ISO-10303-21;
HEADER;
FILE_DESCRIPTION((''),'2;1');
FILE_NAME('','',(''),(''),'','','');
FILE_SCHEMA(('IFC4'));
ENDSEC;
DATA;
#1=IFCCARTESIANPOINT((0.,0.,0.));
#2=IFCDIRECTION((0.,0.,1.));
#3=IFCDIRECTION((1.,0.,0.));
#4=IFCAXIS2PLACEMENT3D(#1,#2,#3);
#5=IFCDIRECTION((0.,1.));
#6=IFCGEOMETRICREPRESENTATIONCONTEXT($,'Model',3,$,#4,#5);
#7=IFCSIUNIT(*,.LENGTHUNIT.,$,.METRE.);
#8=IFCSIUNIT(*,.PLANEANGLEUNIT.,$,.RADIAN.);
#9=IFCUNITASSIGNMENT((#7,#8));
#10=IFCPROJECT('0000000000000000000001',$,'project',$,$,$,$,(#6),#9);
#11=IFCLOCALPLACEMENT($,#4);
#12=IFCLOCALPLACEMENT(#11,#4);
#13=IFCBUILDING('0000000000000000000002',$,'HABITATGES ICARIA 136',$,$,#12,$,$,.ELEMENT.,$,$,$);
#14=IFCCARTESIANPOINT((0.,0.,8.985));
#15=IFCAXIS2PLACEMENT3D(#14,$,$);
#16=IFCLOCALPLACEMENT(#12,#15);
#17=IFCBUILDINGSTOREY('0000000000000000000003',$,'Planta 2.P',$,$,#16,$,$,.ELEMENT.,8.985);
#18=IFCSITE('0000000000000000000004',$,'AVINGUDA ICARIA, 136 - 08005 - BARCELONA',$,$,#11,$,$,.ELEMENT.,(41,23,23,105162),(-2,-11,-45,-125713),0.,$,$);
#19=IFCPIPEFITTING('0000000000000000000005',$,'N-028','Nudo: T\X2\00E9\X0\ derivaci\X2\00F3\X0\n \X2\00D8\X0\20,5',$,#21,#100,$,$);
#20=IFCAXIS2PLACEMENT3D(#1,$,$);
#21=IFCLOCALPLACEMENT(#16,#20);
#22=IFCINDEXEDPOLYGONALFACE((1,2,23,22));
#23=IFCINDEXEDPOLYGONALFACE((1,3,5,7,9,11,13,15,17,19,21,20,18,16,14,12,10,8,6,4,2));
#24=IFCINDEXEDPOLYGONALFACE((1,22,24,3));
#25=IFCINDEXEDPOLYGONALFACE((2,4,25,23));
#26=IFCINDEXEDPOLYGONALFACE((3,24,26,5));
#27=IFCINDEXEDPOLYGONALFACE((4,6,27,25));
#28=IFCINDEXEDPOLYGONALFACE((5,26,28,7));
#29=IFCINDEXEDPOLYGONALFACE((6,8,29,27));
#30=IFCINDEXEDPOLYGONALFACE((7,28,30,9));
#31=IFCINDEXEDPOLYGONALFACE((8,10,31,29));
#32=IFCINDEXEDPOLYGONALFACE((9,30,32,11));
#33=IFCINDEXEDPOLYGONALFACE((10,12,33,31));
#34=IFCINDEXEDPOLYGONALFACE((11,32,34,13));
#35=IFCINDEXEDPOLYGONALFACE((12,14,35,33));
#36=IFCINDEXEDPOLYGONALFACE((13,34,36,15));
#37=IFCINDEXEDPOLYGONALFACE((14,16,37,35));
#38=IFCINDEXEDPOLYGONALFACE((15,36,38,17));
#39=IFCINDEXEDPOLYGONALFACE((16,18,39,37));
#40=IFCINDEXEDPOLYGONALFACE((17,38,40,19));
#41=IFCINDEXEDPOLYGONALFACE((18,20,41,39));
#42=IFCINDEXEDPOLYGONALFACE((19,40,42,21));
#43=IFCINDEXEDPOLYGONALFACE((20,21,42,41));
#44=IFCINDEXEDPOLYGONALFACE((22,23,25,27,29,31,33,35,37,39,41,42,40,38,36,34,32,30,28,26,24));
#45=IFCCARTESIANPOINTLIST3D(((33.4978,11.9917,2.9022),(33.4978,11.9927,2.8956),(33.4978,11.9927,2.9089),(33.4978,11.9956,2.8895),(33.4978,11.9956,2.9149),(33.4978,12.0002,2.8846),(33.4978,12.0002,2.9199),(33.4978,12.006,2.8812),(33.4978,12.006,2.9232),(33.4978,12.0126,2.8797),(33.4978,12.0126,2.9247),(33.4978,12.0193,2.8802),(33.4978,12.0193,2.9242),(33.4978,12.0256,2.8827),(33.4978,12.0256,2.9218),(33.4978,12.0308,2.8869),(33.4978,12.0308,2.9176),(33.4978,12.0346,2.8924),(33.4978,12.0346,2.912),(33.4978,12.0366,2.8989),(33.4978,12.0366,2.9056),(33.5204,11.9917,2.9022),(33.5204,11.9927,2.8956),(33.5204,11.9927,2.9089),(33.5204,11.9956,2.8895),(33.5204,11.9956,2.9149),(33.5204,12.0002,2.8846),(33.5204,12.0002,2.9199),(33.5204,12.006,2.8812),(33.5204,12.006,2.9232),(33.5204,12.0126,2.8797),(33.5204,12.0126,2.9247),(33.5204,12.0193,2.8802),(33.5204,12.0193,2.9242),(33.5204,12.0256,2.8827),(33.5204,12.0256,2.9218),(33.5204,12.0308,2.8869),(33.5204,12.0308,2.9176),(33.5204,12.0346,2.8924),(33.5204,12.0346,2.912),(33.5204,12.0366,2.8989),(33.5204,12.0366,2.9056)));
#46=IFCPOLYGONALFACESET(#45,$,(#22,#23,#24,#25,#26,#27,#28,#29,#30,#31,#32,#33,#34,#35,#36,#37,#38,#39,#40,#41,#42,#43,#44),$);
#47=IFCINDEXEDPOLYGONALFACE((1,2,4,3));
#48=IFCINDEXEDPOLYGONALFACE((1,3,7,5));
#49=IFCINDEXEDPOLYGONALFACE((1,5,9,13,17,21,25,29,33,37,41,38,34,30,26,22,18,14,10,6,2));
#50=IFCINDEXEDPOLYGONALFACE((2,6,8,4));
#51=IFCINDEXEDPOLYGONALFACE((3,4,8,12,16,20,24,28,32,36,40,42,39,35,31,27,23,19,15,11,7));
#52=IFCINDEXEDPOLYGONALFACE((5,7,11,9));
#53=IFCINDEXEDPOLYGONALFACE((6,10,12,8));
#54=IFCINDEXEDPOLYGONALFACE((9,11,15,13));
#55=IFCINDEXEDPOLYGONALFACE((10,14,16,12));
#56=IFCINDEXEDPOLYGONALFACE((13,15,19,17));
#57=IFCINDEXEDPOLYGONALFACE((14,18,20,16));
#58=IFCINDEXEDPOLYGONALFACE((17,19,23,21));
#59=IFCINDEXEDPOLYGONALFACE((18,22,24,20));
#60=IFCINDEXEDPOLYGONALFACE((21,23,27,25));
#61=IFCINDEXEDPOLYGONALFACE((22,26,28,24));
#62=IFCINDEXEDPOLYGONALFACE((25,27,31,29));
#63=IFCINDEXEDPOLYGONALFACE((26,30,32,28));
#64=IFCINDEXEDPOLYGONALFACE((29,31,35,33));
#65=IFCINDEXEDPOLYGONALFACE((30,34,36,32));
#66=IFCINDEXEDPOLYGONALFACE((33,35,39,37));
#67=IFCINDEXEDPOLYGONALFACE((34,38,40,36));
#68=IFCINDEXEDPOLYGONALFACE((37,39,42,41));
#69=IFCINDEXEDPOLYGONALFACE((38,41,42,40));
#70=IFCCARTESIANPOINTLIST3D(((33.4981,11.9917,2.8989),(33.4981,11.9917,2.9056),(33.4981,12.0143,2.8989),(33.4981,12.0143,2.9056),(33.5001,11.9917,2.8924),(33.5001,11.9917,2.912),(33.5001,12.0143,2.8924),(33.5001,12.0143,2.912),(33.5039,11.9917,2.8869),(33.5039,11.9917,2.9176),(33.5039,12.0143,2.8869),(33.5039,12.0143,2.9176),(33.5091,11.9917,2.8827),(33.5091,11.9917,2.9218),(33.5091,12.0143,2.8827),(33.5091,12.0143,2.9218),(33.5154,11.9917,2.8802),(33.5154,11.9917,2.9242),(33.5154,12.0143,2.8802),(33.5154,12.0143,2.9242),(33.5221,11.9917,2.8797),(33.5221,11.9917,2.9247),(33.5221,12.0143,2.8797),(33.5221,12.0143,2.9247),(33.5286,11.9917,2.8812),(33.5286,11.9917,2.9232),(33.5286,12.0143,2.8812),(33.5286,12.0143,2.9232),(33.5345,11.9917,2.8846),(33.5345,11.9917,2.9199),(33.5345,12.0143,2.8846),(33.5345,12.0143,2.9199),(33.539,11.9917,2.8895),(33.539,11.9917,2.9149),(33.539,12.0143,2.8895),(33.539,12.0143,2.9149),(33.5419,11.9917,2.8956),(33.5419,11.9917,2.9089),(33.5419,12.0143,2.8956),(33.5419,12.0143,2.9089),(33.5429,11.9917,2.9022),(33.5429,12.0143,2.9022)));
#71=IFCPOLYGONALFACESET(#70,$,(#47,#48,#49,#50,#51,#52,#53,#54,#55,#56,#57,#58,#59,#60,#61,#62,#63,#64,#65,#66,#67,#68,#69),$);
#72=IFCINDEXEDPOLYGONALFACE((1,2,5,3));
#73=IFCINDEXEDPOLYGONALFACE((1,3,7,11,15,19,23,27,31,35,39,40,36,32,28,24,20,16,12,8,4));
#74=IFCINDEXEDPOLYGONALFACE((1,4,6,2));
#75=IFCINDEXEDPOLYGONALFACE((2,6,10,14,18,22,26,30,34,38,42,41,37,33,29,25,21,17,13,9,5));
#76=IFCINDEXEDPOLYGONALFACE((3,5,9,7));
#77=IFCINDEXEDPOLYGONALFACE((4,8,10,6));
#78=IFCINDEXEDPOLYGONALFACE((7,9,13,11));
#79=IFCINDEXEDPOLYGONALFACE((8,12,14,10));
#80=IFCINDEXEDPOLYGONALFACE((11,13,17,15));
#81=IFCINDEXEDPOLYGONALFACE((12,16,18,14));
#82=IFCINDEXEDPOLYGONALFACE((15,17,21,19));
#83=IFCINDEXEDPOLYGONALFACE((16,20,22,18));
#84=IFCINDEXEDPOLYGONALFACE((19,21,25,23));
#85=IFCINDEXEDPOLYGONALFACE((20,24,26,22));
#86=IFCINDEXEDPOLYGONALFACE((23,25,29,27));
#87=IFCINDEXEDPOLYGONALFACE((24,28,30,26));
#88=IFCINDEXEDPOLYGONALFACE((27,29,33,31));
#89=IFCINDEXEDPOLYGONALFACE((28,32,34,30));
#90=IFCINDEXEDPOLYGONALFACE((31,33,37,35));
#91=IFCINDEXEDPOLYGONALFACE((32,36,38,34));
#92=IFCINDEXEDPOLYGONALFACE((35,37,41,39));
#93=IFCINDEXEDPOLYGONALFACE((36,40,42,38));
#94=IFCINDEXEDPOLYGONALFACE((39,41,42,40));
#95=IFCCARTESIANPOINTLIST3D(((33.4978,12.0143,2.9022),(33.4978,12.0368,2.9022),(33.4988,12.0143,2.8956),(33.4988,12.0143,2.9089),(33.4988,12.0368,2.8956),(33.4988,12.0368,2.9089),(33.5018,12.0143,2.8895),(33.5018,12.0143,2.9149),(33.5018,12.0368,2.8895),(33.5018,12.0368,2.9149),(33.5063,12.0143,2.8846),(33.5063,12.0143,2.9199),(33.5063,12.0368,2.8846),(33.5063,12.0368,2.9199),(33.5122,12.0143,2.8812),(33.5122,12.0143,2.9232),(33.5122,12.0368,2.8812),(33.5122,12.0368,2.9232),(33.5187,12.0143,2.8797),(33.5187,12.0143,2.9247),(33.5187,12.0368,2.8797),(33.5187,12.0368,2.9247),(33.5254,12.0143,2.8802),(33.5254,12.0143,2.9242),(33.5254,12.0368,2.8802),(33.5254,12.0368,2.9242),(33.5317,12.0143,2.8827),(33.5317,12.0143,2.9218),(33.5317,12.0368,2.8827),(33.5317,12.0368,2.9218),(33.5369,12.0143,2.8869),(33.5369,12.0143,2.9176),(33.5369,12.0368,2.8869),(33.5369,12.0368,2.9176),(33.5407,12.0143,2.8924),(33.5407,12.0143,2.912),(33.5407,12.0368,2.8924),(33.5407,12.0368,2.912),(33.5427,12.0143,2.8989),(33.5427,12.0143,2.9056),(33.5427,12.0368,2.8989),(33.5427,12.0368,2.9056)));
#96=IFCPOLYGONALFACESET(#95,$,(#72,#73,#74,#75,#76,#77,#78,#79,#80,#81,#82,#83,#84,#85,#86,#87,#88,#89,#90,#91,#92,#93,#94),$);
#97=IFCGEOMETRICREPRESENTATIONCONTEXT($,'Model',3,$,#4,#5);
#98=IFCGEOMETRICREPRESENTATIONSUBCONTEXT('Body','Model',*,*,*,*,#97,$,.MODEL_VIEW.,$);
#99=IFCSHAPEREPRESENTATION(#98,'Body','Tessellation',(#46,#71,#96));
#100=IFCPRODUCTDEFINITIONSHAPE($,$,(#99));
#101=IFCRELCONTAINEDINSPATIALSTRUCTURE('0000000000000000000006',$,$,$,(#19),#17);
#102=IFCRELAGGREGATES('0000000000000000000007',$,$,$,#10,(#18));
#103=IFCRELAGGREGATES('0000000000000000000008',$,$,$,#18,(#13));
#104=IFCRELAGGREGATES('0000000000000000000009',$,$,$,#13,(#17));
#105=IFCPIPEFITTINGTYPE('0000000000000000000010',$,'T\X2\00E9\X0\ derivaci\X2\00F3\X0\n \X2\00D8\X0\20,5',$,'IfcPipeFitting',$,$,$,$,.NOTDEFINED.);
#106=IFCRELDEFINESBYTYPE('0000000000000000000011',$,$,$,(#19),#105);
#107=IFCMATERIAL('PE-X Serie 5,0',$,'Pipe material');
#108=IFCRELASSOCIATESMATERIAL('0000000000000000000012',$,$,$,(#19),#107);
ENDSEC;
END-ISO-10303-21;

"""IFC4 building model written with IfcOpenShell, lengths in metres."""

from ifc_helpers import new_model, si_unit, direction, frame, origin_with_axes, origin_2d_with_axis, place, context, subcontext, project, spatial, circle, extrude, source, transform, mapped, material, type_object, element, save


model = new_model("IFC4")

# Units and contexts
model_context_1 = context("Model", 3, world=origin_with_axes(), true_north=direction((0.0, 1.0)))
model_context_2 = context("Model", 3, world=origin_with_axes(), true_north=direction((0.0, 1.0)))
body_context_1 = subcontext(model_context_2, "Body", "Model", "MODEL_VIEW")
ifc_project = project(units=[si_unit("LENGTHUNIT", "METRE"), si_unit("PLANEANGLEUNIT", "RADIAN")], contexts=[model_context_1])

# Site, building, storey
site_placement = place(None, origin_with_axes())
site = spatial("IfcSite", under=ifc_project, at=site_placement, Name="AVINGUDA ICARIA, 136 - 08005 - BARCELONA", CompositionType="ELEMENT", RefLatitude=(41, 23, 23, 105162), RefLongitude=(-2, -11, -45, -125713), RefElevation=0.0)
building_placement = place(site_placement, origin_with_axes())
building = spatial("IfcBuilding", under=site, at=building_placement, Name="HABITATGES ICARIA 136", CompositionType="ELEMENT")
storey_placement = place(building_placement, frame((0.0, 0.0, 8.985)))
storey = spatial("IfcBuildingStorey", under=building, at=storey_placement, Name="Planta 2.P", CompositionType="ELEMENT", Elevation=8.985)

# Shared definitions
ifc_material_1 = material(Name="PE-X Serie 5,0", Category="Pipe material")
placement_1 = place(None, origin_with_axes())
placement_2 = place(placement_1, origin_with_axes())
placement_3 = place(placement_2, frame((0.0, 0.0, 8.985)))

# Pipe fitting
pipe_fitting_type_1 = type_object("IfcPipeFittingType", Name="Té derivación Ø20,5", ApplicableOccurrence="IfcPipeFitting", PredefinedType="NOTDEFINED")
shared_shape_1 = source(origin_with_axes(), body_context_1, "Body", "SweptSolid", [
    extrude(circle(Radius=0.0226, at=origin_2d_with_axis()), frame((0.0, 0.0, 0.0), z_axis=(-1.0, 0.0, 0.0), x_axis=(0.0, -1.0, 0.0)), (0.0, 0.0, 1.0), 0.0226),
    extrude(circle(Radius=0.0226, at=origin_2d_with_axis()), frame((0.0, 0.0, 0.0), z_axis=(0.0, -1.0, 0.0), x_axis=(1.0, 0.0, 0.0)), (0.0, 0.0, 1.0), 0.0226),
    extrude(circle(Radius=0.0226, at=origin_2d_with_axis()), frame((0.0, 0.0, 0.0), z_axis=(0.0, 1.0, 0.0), x_axis=(-1.0, 0.0, 0.0)), (0.0, 0.0, 1.0), 0.0226),
])
pipe_fitting_1_placement = place(placement_3, origin_with_axes())
element("IfcPipeFitting", 1, at=pipe_fitting_1_placement, inside=storey, type_object=pipe_fitting_type_1, material=ifc_material_1, Name="N-028", Description="Nudo: Té derivación Ø20,5", context=body_context_1, shape_type="MappedRepresentation", body=[
    mapped(shared_shape_1, transform((33.5204, 12.0143, 2.9022), x_axis=(1.0, 0.0, 0.0), y_axis=(0.0, 1.0, 0.0), z_axis=(0.0, 0.0, 1.0), scale=1.0)),
])

save(model, "model.ifc")
